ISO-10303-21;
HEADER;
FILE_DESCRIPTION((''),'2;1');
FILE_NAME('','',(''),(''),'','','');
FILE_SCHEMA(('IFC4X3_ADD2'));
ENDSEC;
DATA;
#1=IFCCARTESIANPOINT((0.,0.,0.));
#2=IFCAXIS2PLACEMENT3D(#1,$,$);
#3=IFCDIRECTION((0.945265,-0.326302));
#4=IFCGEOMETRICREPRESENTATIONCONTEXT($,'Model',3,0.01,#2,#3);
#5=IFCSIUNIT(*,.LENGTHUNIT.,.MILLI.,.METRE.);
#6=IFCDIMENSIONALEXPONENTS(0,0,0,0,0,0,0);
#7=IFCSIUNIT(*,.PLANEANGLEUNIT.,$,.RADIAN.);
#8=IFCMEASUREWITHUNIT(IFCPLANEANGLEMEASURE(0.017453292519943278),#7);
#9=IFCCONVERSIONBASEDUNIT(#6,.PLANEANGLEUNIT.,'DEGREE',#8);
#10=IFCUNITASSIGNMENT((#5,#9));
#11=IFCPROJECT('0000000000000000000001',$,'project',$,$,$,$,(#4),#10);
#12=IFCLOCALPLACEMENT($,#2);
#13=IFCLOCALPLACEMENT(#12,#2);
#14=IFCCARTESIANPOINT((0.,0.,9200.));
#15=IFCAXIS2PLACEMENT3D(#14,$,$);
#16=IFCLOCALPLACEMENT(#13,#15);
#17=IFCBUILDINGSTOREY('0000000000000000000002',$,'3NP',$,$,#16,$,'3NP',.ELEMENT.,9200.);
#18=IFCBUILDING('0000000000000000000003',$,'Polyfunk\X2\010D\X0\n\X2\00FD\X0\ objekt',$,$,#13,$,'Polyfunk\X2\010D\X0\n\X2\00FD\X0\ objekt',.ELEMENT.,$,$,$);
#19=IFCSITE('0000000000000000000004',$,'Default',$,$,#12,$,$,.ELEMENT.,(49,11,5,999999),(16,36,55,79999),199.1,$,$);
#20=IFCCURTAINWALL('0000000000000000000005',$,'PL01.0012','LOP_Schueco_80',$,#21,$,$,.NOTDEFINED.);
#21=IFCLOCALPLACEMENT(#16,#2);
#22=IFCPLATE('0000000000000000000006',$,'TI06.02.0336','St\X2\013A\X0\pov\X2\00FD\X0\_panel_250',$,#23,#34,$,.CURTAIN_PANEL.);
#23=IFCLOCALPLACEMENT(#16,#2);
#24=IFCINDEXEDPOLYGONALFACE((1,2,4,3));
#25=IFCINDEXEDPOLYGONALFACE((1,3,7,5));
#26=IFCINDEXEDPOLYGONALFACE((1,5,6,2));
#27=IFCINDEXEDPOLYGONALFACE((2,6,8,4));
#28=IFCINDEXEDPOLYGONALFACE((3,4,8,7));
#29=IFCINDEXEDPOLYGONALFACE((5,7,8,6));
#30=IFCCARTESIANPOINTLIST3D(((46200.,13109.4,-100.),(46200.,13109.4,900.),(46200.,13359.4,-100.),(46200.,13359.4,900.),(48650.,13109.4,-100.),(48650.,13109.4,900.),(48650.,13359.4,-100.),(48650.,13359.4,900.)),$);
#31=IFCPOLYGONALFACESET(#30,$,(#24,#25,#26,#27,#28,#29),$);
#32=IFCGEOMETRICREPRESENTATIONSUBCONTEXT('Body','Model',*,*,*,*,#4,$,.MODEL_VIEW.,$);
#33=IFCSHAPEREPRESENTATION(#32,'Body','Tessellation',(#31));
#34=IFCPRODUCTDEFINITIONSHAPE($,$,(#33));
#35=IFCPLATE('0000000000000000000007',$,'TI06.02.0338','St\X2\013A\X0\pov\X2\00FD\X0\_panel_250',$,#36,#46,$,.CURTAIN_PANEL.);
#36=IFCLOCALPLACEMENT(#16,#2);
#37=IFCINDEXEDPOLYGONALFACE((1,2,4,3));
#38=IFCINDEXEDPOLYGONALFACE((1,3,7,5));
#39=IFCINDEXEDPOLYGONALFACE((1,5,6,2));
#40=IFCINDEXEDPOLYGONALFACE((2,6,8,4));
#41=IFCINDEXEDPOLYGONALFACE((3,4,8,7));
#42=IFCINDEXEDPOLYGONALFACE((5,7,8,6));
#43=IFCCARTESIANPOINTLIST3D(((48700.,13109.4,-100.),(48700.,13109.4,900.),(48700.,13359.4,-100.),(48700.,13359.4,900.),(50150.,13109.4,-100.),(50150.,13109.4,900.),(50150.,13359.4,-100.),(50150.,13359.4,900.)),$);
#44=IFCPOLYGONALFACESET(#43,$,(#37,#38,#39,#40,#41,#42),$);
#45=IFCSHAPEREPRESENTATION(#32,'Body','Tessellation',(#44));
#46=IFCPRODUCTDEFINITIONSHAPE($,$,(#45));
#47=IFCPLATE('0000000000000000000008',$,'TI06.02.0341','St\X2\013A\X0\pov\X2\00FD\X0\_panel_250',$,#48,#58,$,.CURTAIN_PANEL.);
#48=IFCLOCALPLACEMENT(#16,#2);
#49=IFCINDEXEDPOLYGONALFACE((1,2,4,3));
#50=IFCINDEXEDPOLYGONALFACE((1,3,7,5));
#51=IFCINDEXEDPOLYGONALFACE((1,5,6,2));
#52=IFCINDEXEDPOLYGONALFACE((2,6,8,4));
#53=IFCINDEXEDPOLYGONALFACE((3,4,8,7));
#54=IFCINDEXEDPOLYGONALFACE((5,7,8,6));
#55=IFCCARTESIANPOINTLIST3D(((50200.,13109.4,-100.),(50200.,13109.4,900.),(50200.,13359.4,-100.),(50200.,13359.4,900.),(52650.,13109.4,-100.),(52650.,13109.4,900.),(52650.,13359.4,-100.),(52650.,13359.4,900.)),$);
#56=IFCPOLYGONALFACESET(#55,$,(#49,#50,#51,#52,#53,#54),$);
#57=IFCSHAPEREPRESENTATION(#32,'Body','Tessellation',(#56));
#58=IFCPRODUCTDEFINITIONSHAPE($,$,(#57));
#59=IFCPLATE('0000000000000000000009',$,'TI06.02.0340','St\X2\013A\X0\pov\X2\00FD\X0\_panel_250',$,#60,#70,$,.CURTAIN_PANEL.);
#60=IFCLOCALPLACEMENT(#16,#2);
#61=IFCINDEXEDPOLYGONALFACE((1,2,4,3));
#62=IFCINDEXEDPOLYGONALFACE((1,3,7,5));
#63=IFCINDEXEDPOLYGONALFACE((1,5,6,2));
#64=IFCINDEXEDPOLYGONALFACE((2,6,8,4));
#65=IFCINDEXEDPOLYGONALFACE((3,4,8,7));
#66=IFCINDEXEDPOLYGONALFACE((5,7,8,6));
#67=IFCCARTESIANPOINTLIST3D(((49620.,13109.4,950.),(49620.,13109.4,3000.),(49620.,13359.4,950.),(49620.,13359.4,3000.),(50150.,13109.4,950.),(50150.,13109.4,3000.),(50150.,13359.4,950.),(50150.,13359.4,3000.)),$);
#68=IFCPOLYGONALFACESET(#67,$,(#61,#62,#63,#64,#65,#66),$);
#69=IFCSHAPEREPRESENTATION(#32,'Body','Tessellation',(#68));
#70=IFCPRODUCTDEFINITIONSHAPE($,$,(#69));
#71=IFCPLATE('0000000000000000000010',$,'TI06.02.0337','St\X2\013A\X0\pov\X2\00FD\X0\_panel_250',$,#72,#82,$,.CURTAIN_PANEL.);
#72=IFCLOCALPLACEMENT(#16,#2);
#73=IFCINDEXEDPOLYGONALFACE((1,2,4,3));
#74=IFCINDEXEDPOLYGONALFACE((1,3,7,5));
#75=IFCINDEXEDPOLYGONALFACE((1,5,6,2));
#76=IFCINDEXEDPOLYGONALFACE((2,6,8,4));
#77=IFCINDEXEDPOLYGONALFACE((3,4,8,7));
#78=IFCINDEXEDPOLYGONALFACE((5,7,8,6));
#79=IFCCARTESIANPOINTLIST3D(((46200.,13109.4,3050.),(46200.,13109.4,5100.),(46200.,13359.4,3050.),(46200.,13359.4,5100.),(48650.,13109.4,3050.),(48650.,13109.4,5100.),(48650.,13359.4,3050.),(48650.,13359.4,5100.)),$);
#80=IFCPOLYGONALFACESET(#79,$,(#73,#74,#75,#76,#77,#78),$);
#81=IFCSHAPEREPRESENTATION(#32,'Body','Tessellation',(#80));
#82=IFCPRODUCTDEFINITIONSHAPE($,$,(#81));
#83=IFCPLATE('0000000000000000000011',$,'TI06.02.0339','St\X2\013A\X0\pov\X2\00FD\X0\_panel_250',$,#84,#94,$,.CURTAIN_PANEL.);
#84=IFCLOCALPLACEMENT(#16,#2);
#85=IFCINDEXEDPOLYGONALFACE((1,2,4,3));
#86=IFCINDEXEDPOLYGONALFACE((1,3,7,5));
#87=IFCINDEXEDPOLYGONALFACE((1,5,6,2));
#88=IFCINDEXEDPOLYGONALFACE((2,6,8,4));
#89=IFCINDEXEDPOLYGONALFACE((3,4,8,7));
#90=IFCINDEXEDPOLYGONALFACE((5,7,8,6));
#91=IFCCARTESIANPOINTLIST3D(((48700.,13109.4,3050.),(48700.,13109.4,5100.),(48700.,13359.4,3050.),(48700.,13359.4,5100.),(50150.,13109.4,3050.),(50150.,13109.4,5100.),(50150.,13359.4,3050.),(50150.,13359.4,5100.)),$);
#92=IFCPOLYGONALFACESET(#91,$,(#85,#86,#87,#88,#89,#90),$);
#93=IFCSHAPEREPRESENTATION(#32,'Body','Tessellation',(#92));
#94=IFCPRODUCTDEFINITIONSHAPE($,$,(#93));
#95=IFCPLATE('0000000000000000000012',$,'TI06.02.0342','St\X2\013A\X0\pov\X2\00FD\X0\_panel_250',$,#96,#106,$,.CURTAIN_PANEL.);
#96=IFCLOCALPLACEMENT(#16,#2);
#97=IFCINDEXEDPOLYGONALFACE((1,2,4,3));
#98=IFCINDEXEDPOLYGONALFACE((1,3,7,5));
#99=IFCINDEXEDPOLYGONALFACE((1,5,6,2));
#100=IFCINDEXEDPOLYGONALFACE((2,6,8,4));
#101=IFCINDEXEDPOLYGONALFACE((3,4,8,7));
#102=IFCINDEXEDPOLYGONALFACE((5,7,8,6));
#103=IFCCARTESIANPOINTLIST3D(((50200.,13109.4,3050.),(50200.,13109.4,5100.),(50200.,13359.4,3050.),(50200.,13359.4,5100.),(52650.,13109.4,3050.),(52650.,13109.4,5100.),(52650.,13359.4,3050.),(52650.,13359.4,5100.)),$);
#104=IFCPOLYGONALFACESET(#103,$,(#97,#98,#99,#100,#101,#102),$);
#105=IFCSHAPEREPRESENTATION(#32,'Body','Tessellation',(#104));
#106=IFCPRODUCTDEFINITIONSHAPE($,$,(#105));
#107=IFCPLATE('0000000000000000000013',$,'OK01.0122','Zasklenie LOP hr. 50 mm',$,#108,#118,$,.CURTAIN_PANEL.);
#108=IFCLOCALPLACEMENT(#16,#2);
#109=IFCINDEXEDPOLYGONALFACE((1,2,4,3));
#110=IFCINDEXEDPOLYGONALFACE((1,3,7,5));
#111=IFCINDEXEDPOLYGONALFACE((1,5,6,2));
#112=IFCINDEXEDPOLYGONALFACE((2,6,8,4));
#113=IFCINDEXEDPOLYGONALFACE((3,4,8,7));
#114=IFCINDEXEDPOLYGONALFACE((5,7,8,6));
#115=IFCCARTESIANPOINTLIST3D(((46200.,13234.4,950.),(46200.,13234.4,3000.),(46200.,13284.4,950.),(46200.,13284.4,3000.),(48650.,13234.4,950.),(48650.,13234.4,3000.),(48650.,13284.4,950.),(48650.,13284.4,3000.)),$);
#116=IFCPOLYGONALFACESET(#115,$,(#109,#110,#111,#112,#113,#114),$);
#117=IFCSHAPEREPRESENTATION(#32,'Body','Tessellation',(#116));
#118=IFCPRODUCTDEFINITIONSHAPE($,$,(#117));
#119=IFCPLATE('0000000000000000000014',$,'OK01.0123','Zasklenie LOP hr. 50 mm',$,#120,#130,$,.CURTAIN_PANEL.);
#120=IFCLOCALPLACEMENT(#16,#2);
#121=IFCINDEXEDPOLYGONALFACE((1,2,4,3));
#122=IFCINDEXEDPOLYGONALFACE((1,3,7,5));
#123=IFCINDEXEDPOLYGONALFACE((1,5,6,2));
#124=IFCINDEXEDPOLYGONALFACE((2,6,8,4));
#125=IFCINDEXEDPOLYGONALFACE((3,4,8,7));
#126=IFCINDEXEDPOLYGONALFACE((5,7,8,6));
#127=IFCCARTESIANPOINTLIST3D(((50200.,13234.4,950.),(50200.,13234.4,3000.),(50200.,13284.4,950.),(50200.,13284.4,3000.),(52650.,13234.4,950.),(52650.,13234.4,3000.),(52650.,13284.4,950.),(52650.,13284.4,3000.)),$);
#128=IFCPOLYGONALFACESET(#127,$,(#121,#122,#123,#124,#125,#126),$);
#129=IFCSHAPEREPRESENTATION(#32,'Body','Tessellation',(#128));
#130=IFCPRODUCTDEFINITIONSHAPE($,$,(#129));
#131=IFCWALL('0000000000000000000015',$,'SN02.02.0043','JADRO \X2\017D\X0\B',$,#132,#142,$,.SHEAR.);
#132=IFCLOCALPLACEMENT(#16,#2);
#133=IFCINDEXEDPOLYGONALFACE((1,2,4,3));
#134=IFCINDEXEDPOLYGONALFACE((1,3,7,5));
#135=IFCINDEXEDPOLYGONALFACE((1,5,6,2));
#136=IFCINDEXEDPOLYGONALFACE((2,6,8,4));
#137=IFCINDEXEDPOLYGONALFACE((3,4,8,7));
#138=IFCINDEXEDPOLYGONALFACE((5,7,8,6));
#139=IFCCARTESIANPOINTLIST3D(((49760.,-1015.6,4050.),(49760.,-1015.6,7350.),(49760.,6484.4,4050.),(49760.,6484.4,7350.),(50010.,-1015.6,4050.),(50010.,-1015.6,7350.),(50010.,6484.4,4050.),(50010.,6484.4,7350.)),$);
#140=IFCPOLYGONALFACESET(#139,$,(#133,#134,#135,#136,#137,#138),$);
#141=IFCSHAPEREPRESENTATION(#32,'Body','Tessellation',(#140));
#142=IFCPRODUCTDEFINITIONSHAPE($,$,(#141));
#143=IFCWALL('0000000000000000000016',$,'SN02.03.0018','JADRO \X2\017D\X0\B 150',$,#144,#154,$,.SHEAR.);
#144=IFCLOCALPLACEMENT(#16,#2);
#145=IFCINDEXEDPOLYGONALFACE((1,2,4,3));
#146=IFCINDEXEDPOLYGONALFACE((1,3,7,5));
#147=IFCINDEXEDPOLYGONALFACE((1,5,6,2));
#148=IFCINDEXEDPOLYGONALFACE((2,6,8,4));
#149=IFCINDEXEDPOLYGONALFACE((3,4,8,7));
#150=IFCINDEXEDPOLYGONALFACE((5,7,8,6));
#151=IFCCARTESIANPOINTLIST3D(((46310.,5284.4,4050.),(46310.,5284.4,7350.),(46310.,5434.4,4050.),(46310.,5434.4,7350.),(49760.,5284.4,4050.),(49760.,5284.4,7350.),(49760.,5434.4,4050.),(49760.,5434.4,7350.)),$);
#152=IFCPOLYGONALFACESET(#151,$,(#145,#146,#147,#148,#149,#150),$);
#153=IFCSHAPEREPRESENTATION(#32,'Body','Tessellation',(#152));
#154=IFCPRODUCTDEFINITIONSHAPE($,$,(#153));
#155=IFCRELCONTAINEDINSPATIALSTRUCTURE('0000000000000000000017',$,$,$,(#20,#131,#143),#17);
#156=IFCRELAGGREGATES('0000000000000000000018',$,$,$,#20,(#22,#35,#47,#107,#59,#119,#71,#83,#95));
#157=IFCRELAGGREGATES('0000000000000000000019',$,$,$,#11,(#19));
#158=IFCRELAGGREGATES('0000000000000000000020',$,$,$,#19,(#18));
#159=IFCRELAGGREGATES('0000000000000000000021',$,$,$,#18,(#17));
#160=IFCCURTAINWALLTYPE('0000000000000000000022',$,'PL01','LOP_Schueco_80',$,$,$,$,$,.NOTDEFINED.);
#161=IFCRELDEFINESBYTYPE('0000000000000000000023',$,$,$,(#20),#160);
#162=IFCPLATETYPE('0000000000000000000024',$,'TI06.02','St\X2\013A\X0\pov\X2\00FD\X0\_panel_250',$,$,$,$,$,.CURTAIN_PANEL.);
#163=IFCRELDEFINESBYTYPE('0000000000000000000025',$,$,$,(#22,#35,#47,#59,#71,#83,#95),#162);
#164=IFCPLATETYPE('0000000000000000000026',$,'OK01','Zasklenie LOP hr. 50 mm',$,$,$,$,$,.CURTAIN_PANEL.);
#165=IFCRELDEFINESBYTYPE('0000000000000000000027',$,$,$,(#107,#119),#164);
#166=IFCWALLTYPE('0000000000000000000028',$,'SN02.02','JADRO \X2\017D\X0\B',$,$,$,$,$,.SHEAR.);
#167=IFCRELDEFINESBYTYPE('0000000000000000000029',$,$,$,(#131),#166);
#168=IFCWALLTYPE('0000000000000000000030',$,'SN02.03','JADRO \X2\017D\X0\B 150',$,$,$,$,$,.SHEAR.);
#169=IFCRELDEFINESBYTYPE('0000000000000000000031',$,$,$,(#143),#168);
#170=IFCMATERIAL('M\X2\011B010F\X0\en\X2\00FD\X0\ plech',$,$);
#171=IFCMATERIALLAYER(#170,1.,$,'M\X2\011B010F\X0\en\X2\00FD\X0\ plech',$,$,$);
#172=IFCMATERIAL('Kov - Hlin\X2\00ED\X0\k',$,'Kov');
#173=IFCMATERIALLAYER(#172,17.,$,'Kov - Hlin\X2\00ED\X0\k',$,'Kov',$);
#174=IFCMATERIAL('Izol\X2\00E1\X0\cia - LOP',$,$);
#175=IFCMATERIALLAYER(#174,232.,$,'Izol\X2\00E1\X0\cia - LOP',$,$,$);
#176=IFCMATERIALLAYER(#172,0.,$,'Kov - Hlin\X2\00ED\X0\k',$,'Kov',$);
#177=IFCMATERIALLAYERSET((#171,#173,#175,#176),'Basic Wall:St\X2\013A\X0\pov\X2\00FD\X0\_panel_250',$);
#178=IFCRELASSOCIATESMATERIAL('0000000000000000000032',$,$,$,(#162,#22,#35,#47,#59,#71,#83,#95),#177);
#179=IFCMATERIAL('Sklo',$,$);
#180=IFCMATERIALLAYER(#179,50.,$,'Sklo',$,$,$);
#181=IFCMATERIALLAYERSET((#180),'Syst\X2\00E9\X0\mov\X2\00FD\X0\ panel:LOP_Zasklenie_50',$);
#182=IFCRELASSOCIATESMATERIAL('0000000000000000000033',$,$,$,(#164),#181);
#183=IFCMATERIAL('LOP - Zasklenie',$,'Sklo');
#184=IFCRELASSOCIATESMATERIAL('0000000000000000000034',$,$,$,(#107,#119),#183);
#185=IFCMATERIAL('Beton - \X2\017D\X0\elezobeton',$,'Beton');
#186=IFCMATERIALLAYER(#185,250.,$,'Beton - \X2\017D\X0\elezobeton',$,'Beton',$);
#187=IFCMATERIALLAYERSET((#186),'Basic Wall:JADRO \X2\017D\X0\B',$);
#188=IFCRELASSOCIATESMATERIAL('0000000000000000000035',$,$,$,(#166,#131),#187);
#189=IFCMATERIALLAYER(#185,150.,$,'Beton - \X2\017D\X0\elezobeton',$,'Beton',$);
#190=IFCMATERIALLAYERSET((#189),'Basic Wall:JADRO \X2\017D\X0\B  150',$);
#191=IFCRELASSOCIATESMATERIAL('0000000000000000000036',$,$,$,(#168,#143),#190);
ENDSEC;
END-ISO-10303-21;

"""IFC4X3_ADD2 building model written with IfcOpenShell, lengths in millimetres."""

from ifc_helpers import new_model, entity, si_unit, converted_unit, direction, frame, frame_2d, origin, origin_2d_with_axis, place, context, subcontext, project, spatial, polyline, rectangle, extrude, clip, bounded_halfspace, source, transform, mapped, material, layer, layer_set, layer_usage, type_object, type_shapes, element, aggregate, save


model = new_model("IFC4X3_ADD2")

# Units and contexts
model_context = context("Model", 3, precision=0.01, world=origin(), true_north=direction((0.945265, -0.326302)))
body_context = subcontext(model_context, "Body", "Model", "MODEL_VIEW")
ifc_project = project(units=[si_unit("LENGTHUNIT", "METRE", prefix="MILLI"), converted_unit("PLANEANGLEUNIT", "DEGREE", entity("IfcPlaneAngleMeasure", 0.017453292519943278), si_unit("PLANEANGLEUNIT", "RADIAN"), dimensions=[0, 0, 0, 0, 0, 0, 0])], contexts=[model_context])

# Site, building, storey
site_placement = place(None, origin())
site = spatial("IfcSite", under=ifc_project, at=site_placement, Name="Default", CompositionType="ELEMENT", RefLatitude=(49, 11, 5, 999999), RefLongitude=(16, 36, 55, 79999), RefElevation=199.1)
building_placement = place(site_placement, origin())
building = spatial("IfcBuilding", under=site, at=building_placement, Name="Polyfunkčný objekt", LongName="Polyfunkčný objekt", CompositionType="ELEMENT")
storey_placement = place(building_placement, frame((0.0, 0.0, 9200.0)))
storey = spatial("IfcBuildingStorey", under=building, at=storey_placement, Name="3NP", LongName="3NP", CompositionType="ELEMENT", Elevation=9200.0)

# Curtain wall, plates
curtain_wall_type = type_object("IfcCurtainWallType", Name="PL01", Description="LOP_Schueco_80", PredefinedType="NOTDEFINED")
curtain_wall_placement = place(storey_placement, frame((0.0, 0.0, -9200.0)))
curtain_wall = element("IfcCurtainWall", 1, at=curtain_wall_placement, inside=storey, type_object=curtain_wall_type, Name="PL01.0012", Description="LOP_Schueco_80", PredefinedType="NOTDEFINED")
ifc_material_1 = material(Name="Měďený plech")
ifc_layer_1 = layer(ifc_material_1, 1.0, Name="Měďený plech")
ifc_material_2 = material(Name="Kov - Hliník", Category="Kov")
ifc_layer_2 = layer(ifc_material_2, 17.0, Name="Kov - Hliník", Category="Kov")
ifc_material_3 = material(Name="Izolácia - LOP")
ifc_layer_3 = layer(ifc_material_3, 232.0, Name="Izolácia - LOP")
ifc_layer_4 = layer(ifc_material_2, 0.0, Name="Kov - Hliník", Category="Kov")
ifc_layer_set_1 = layer_set([ifc_layer_1, ifc_layer_2, ifc_layer_3, ifc_layer_4], Name="Basic Wall:Stĺpový_panel_250")
ifc_layer_usage_1 = layer_usage(ifc_layer_set_1, "AXIS2", "NEGATIVE", 125.0)
plate_type_1 = type_object("IfcPlateType", Name="TI06.02", Description="Stĺpový_panel_250", PredefinedType="CURTAIN_PANEL", material=ifc_layer_set_1)
plate_1_placement = place(storey_placement, frame((46200.0, 13234.4, -100.0)))
plate_1 = element("IfcPlate", 2, at=plate_1_placement, type_object=plate_type_1, material=ifc_layer_usage_1, Name="TI06.02.0336", Description="Stĺpový_panel_250", PredefinedType="CURTAIN_PANEL", context=body_context, shape_type="SweptSolid", body=[
    extrude(rectangle(XDim=250.0, YDim=2450.0, at=frame_2d((0.0, 0.0), x_axis=(1.0, 0.0))), frame((1225.0, 0.0, 0.0), z_axis=(0.0, 0.0, 1.0), x_axis=(0.0, 1.0, 0.0)), (0.0, 0.0, 1.0), 1000.0),
])
ifc_layer_usage_2 = layer_usage(ifc_layer_set_1, "AXIS2", "NEGATIVE", 125.0)
plate_2_placement = place(storey_placement, frame((48700.0, 13234.4, -100.0)))
plate_2 = element("IfcPlate", 3, at=plate_2_placement, type_object=plate_type_1, material=ifc_layer_usage_2, Name="TI06.02.0338", Description="Stĺpový_panel_250", PredefinedType="CURTAIN_PANEL", context=body_context, shape_type="SweptSolid", body=[
    extrude(rectangle(XDim=250.0, YDim=1450.0, at=frame_2d((0.0, 0.0), x_axis=(1.0, 0.0))), frame((725.0, 0.0, 0.0), z_axis=(0.0, 0.0, 1.0), x_axis=(0.0, 1.0, 0.0)), (0.0, 0.0, 1.0), 1000.0),
])
ifc_layer_usage_3 = layer_usage(ifc_layer_set_1, "AXIS2", "NEGATIVE", 125.0)
plate_3_placement = place(storey_placement, frame((50200.0, 13234.4, -100.0)))
plate_3 = element("IfcPlate", 4, at=plate_3_placement, type_object=plate_type_1, material=ifc_layer_usage_3, Name="TI06.02.0341", Description="Stĺpový_panel_250", PredefinedType="CURTAIN_PANEL", context=body_context, shape_type="SweptSolid", body=[
    extrude(rectangle(XDim=250.0, YDim=2450.0, at=origin_2d_with_axis()), frame((1225.0, 0.0, 0.0), z_axis=(0.0, 0.0, 1.0), x_axis=(0.0, 1.0, 0.0)), (0.0, 0.0, 1.0), 1000.0),
])
ifc_layer_usage_4 = layer_usage(ifc_layer_set_1, "AXIS2", "NEGATIVE", 125.0)
plate_4_placement = place(storey_placement, frame((49620.0, 13234.4, 950.0)))
plate_4 = element("IfcPlate", 5, at=plate_4_placement, type_object=plate_type_1, material=ifc_layer_usage_4, Name="TI06.02.0340", Description="Stĺpový_panel_250", PredefinedType="CURTAIN_PANEL", context=body_context, shape_type="SweptSolid", body=[
    extrude(rectangle(XDim=250.0, YDim=530.0, at=frame_2d((0.0, 0.0), x_axis=(1.0, 0.0))), frame((265.0, 0.0, 0.0), z_axis=(0.0, 0.0, 1.0), x_axis=(0.0, 1.0, 0.0)), (0.0, 0.0, 1.0), 2050.0),
])
ifc_layer_usage_5 = layer_usage(ifc_layer_set_1, "AXIS2", "NEGATIVE", 125.0)
plate_5_placement = place(storey_placement, frame((46200.0, 13234.4, 3050.0)))
plate_5 = element("IfcPlate", 6, at=plate_5_placement, type_object=plate_type_1, material=ifc_layer_usage_5, Name="TI06.02.0337", Description="Stĺpový_panel_250", PredefinedType="CURTAIN_PANEL", context=body_context, shape_type="SweptSolid", body=[
    extrude(rectangle(XDim=250.0, YDim=2450.0, at=frame_2d((0.0, 0.0), x_axis=(1.0, 0.0))), frame((1225.0, 0.0, 0.0), z_axis=(0.0, 0.0, 1.0), x_axis=(0.0, 1.0, 0.0)), (0.0, 0.0, 1.0), 2050.0),
])
ifc_layer_usage_6 = layer_usage(ifc_layer_set_1, "AXIS2", "NEGATIVE", 125.0)
plate_6_placement = place(storey_placement, frame((48700.0, 13234.4, 3050.0)))
plate_6 = element("IfcPlate", 7, at=plate_6_placement, type_object=plate_type_1, material=ifc_layer_usage_6, Name="TI06.02.0339", Description="Stĺpový_panel_250", PredefinedType="CURTAIN_PANEL", context=body_context, shape_type="SweptSolid", body=[
    extrude(rectangle(XDim=250.0, YDim=1450.0, at=frame_2d((0.0, 0.0), x_axis=(1.0, 0.0))), frame((725.0, 0.0, 0.0), z_axis=(0.0, 0.0, 1.0), x_axis=(0.0, 1.0, 0.0)), (0.0, 0.0, 1.0), 2050.0),
])
ifc_layer_usage_7 = layer_usage(ifc_layer_set_1, "AXIS2", "NEGATIVE", 125.0)
plate_7_placement = place(storey_placement, frame((50200.0, 13234.4, 3050.0)))
plate_7 = element("IfcPlate", 8, at=plate_7_placement, type_object=plate_type_1, material=ifc_layer_usage_7, Name="TI06.02.0342", Description="Stĺpový_panel_250", PredefinedType="CURTAIN_PANEL", context=body_context, shape_type="SweptSolid", body=[
    extrude(rectangle(XDim=250.0, YDim=2450.0, at=origin_2d_with_axis()), frame((1225.0, 0.0, 0.0), z_axis=(0.0, 0.0, 1.0), x_axis=(0.0, 1.0, 0.0)), (0.0, 0.0, 1.0), 2050.0),
])
ifc_material_4 = material(Name="LOP - Zasklenie", Category="Sklo")
ifc_material_5 = material(Name="Sklo")
ifc_layer_5 = layer(ifc_material_5, 50.0, Name="Sklo")
ifc_layer_set_2 = layer_set([ifc_layer_5], Name="Systémový panel:LOP_Zasklenie_50")
plate_type_2 = type_object("IfcPlateType", Name="OK01", Description="Zasklenie LOP hr. 50 mm", PredefinedType="CURTAIN_PANEL", material=ifc_layer_set_2)
shared_shape_1 = source(origin(), body_context, "Body", "SweptSolid", [
    extrude(rectangle(XDim=50.0, YDim=2450.0, at=origin_2d_with_axis()), frame((0.0, 25.0, 0.0), z_axis=(0.0, 0.0, 1.0), x_axis=(0.0, 1.0, 0.0)), (0.0, 0.0, 1.0), 2050.0),
])
type_shapes(plate_type_2, [shared_shape_1])
plate_8_placement = place(curtain_wall_placement, frame((47425.0, 13234.4, 10150.0)))
plate_8 = element("IfcPlate", 9, at=plate_8_placement, type_object=plate_type_2, material=ifc_material_4, Name="OK01.0122", Description="Zasklenie LOP hr. 50 mm", PredefinedType="CURTAIN_PANEL", context=body_context, shape_type="MappedRepresentation", body=[
    mapped(shared_shape_1, transform((0.0, 0.0, 0.0), scale=1.0)),
])
plate_9_placement = place(curtain_wall_placement, frame((51425.0, 13234.4, 10150.0)))
plate_9 = element("IfcPlate", 10, at=plate_9_placement, type_object=plate_type_2, material=ifc_material_4, Name="OK01.0123", Description="Zasklenie LOP hr. 50 mm", PredefinedType="CURTAIN_PANEL", context=body_context, shape_type="MappedRepresentation", body=[
    mapped(shared_shape_1, transform((0.0, 0.0, 0.0), scale=1.0)),
])

# Walls
ifc_material_6 = material(Name="Beton - Železobeton", Category="Beton")
ifc_layer_6 = layer(ifc_material_6, 250.0, Name="Beton - Železobeton", Category="Beton")
ifc_layer_set_3 = layer_set([ifc_layer_6], Name="Basic Wall:JADRO ŽB")
wall_type_1 = type_object("IfcWallType", Name="SN02.02", Description="JADRO ŽB", PredefinedType="SHEAR", material=ifc_layer_set_3)
wall_1_placement = place(storey_placement, frame((49885.0, 6484.4, 4050.0), z_axis=(0.0, 0.0, 1.0), x_axis=(0.0, -1.0, 0.0)))
element("IfcWall", 11, at=wall_1_placement, inside=storey, type_object=wall_type_1, material=ifc_layer_set_3, Name="SN02.02.0043", Description="JADRO ŽB", PredefinedType="SHEAR", context=body_context, shape_type="Clipping", body=[
    clip(extrude(rectangle(XDim=7500.0, YDim=250.0, at=frame_2d((3750.0, 0.0), x_axis=(-1.0, 0.0))), origin(), (0.0, 0.0, 1.0), 3300.0), bounded_halfspace(frame((0.0, -125.0, 3300.0), z_axis=(0.0, 0.0, -1.0), x_axis=(1.0, 0.0, 0.0)), True, frame((0.0, -125.0, 3300.0)), polyline([(0.0, 0.0), (250.0, 0.0), (1050.0, 0.0), (1200.0, 0.0), (7500.0, 0.0), (7500.0, 250.0), (0.0, 250.0), (0.0, 0.0)]))),
])
ifc_layer_7 = layer(ifc_material_6, 150.0, Name="Beton - Železobeton", Category="Beton")
ifc_layer_set_4 = layer_set([ifc_layer_7], Name="Basic Wall:JADRO ŽB  150")
wall_type_2 = type_object("IfcWallType", Name="SN02.03", Description="JADRO ŽB 150", PredefinedType="SHEAR", material=ifc_layer_set_4)
wall_2_placement = place(storey_placement, frame((46310.0, 5359.4, 4050.0)))
element("IfcWall", 12, at=wall_2_placement, inside=storey, type_object=wall_type_2, material=ifc_layer_set_4, Name="SN02.03.0018", Description="JADRO ŽB 150", PredefinedType="SHEAR", context=body_context, shape_type="SweptSolid", body=[
    extrude(rectangle(XDim=3450.0, YDim=150.0, at=frame_2d((1725.0, 0.0), x_axis=(-1.0, 0.0))), origin(), (0.0, 0.0, 1.0), 3300.0),
])

aggregate(curtain_wall, [plate_1, plate_2, plate_3, plate_8, plate_4, plate_9, plate_5, plate_6, plate_7])

save(model, "model.ifc")
